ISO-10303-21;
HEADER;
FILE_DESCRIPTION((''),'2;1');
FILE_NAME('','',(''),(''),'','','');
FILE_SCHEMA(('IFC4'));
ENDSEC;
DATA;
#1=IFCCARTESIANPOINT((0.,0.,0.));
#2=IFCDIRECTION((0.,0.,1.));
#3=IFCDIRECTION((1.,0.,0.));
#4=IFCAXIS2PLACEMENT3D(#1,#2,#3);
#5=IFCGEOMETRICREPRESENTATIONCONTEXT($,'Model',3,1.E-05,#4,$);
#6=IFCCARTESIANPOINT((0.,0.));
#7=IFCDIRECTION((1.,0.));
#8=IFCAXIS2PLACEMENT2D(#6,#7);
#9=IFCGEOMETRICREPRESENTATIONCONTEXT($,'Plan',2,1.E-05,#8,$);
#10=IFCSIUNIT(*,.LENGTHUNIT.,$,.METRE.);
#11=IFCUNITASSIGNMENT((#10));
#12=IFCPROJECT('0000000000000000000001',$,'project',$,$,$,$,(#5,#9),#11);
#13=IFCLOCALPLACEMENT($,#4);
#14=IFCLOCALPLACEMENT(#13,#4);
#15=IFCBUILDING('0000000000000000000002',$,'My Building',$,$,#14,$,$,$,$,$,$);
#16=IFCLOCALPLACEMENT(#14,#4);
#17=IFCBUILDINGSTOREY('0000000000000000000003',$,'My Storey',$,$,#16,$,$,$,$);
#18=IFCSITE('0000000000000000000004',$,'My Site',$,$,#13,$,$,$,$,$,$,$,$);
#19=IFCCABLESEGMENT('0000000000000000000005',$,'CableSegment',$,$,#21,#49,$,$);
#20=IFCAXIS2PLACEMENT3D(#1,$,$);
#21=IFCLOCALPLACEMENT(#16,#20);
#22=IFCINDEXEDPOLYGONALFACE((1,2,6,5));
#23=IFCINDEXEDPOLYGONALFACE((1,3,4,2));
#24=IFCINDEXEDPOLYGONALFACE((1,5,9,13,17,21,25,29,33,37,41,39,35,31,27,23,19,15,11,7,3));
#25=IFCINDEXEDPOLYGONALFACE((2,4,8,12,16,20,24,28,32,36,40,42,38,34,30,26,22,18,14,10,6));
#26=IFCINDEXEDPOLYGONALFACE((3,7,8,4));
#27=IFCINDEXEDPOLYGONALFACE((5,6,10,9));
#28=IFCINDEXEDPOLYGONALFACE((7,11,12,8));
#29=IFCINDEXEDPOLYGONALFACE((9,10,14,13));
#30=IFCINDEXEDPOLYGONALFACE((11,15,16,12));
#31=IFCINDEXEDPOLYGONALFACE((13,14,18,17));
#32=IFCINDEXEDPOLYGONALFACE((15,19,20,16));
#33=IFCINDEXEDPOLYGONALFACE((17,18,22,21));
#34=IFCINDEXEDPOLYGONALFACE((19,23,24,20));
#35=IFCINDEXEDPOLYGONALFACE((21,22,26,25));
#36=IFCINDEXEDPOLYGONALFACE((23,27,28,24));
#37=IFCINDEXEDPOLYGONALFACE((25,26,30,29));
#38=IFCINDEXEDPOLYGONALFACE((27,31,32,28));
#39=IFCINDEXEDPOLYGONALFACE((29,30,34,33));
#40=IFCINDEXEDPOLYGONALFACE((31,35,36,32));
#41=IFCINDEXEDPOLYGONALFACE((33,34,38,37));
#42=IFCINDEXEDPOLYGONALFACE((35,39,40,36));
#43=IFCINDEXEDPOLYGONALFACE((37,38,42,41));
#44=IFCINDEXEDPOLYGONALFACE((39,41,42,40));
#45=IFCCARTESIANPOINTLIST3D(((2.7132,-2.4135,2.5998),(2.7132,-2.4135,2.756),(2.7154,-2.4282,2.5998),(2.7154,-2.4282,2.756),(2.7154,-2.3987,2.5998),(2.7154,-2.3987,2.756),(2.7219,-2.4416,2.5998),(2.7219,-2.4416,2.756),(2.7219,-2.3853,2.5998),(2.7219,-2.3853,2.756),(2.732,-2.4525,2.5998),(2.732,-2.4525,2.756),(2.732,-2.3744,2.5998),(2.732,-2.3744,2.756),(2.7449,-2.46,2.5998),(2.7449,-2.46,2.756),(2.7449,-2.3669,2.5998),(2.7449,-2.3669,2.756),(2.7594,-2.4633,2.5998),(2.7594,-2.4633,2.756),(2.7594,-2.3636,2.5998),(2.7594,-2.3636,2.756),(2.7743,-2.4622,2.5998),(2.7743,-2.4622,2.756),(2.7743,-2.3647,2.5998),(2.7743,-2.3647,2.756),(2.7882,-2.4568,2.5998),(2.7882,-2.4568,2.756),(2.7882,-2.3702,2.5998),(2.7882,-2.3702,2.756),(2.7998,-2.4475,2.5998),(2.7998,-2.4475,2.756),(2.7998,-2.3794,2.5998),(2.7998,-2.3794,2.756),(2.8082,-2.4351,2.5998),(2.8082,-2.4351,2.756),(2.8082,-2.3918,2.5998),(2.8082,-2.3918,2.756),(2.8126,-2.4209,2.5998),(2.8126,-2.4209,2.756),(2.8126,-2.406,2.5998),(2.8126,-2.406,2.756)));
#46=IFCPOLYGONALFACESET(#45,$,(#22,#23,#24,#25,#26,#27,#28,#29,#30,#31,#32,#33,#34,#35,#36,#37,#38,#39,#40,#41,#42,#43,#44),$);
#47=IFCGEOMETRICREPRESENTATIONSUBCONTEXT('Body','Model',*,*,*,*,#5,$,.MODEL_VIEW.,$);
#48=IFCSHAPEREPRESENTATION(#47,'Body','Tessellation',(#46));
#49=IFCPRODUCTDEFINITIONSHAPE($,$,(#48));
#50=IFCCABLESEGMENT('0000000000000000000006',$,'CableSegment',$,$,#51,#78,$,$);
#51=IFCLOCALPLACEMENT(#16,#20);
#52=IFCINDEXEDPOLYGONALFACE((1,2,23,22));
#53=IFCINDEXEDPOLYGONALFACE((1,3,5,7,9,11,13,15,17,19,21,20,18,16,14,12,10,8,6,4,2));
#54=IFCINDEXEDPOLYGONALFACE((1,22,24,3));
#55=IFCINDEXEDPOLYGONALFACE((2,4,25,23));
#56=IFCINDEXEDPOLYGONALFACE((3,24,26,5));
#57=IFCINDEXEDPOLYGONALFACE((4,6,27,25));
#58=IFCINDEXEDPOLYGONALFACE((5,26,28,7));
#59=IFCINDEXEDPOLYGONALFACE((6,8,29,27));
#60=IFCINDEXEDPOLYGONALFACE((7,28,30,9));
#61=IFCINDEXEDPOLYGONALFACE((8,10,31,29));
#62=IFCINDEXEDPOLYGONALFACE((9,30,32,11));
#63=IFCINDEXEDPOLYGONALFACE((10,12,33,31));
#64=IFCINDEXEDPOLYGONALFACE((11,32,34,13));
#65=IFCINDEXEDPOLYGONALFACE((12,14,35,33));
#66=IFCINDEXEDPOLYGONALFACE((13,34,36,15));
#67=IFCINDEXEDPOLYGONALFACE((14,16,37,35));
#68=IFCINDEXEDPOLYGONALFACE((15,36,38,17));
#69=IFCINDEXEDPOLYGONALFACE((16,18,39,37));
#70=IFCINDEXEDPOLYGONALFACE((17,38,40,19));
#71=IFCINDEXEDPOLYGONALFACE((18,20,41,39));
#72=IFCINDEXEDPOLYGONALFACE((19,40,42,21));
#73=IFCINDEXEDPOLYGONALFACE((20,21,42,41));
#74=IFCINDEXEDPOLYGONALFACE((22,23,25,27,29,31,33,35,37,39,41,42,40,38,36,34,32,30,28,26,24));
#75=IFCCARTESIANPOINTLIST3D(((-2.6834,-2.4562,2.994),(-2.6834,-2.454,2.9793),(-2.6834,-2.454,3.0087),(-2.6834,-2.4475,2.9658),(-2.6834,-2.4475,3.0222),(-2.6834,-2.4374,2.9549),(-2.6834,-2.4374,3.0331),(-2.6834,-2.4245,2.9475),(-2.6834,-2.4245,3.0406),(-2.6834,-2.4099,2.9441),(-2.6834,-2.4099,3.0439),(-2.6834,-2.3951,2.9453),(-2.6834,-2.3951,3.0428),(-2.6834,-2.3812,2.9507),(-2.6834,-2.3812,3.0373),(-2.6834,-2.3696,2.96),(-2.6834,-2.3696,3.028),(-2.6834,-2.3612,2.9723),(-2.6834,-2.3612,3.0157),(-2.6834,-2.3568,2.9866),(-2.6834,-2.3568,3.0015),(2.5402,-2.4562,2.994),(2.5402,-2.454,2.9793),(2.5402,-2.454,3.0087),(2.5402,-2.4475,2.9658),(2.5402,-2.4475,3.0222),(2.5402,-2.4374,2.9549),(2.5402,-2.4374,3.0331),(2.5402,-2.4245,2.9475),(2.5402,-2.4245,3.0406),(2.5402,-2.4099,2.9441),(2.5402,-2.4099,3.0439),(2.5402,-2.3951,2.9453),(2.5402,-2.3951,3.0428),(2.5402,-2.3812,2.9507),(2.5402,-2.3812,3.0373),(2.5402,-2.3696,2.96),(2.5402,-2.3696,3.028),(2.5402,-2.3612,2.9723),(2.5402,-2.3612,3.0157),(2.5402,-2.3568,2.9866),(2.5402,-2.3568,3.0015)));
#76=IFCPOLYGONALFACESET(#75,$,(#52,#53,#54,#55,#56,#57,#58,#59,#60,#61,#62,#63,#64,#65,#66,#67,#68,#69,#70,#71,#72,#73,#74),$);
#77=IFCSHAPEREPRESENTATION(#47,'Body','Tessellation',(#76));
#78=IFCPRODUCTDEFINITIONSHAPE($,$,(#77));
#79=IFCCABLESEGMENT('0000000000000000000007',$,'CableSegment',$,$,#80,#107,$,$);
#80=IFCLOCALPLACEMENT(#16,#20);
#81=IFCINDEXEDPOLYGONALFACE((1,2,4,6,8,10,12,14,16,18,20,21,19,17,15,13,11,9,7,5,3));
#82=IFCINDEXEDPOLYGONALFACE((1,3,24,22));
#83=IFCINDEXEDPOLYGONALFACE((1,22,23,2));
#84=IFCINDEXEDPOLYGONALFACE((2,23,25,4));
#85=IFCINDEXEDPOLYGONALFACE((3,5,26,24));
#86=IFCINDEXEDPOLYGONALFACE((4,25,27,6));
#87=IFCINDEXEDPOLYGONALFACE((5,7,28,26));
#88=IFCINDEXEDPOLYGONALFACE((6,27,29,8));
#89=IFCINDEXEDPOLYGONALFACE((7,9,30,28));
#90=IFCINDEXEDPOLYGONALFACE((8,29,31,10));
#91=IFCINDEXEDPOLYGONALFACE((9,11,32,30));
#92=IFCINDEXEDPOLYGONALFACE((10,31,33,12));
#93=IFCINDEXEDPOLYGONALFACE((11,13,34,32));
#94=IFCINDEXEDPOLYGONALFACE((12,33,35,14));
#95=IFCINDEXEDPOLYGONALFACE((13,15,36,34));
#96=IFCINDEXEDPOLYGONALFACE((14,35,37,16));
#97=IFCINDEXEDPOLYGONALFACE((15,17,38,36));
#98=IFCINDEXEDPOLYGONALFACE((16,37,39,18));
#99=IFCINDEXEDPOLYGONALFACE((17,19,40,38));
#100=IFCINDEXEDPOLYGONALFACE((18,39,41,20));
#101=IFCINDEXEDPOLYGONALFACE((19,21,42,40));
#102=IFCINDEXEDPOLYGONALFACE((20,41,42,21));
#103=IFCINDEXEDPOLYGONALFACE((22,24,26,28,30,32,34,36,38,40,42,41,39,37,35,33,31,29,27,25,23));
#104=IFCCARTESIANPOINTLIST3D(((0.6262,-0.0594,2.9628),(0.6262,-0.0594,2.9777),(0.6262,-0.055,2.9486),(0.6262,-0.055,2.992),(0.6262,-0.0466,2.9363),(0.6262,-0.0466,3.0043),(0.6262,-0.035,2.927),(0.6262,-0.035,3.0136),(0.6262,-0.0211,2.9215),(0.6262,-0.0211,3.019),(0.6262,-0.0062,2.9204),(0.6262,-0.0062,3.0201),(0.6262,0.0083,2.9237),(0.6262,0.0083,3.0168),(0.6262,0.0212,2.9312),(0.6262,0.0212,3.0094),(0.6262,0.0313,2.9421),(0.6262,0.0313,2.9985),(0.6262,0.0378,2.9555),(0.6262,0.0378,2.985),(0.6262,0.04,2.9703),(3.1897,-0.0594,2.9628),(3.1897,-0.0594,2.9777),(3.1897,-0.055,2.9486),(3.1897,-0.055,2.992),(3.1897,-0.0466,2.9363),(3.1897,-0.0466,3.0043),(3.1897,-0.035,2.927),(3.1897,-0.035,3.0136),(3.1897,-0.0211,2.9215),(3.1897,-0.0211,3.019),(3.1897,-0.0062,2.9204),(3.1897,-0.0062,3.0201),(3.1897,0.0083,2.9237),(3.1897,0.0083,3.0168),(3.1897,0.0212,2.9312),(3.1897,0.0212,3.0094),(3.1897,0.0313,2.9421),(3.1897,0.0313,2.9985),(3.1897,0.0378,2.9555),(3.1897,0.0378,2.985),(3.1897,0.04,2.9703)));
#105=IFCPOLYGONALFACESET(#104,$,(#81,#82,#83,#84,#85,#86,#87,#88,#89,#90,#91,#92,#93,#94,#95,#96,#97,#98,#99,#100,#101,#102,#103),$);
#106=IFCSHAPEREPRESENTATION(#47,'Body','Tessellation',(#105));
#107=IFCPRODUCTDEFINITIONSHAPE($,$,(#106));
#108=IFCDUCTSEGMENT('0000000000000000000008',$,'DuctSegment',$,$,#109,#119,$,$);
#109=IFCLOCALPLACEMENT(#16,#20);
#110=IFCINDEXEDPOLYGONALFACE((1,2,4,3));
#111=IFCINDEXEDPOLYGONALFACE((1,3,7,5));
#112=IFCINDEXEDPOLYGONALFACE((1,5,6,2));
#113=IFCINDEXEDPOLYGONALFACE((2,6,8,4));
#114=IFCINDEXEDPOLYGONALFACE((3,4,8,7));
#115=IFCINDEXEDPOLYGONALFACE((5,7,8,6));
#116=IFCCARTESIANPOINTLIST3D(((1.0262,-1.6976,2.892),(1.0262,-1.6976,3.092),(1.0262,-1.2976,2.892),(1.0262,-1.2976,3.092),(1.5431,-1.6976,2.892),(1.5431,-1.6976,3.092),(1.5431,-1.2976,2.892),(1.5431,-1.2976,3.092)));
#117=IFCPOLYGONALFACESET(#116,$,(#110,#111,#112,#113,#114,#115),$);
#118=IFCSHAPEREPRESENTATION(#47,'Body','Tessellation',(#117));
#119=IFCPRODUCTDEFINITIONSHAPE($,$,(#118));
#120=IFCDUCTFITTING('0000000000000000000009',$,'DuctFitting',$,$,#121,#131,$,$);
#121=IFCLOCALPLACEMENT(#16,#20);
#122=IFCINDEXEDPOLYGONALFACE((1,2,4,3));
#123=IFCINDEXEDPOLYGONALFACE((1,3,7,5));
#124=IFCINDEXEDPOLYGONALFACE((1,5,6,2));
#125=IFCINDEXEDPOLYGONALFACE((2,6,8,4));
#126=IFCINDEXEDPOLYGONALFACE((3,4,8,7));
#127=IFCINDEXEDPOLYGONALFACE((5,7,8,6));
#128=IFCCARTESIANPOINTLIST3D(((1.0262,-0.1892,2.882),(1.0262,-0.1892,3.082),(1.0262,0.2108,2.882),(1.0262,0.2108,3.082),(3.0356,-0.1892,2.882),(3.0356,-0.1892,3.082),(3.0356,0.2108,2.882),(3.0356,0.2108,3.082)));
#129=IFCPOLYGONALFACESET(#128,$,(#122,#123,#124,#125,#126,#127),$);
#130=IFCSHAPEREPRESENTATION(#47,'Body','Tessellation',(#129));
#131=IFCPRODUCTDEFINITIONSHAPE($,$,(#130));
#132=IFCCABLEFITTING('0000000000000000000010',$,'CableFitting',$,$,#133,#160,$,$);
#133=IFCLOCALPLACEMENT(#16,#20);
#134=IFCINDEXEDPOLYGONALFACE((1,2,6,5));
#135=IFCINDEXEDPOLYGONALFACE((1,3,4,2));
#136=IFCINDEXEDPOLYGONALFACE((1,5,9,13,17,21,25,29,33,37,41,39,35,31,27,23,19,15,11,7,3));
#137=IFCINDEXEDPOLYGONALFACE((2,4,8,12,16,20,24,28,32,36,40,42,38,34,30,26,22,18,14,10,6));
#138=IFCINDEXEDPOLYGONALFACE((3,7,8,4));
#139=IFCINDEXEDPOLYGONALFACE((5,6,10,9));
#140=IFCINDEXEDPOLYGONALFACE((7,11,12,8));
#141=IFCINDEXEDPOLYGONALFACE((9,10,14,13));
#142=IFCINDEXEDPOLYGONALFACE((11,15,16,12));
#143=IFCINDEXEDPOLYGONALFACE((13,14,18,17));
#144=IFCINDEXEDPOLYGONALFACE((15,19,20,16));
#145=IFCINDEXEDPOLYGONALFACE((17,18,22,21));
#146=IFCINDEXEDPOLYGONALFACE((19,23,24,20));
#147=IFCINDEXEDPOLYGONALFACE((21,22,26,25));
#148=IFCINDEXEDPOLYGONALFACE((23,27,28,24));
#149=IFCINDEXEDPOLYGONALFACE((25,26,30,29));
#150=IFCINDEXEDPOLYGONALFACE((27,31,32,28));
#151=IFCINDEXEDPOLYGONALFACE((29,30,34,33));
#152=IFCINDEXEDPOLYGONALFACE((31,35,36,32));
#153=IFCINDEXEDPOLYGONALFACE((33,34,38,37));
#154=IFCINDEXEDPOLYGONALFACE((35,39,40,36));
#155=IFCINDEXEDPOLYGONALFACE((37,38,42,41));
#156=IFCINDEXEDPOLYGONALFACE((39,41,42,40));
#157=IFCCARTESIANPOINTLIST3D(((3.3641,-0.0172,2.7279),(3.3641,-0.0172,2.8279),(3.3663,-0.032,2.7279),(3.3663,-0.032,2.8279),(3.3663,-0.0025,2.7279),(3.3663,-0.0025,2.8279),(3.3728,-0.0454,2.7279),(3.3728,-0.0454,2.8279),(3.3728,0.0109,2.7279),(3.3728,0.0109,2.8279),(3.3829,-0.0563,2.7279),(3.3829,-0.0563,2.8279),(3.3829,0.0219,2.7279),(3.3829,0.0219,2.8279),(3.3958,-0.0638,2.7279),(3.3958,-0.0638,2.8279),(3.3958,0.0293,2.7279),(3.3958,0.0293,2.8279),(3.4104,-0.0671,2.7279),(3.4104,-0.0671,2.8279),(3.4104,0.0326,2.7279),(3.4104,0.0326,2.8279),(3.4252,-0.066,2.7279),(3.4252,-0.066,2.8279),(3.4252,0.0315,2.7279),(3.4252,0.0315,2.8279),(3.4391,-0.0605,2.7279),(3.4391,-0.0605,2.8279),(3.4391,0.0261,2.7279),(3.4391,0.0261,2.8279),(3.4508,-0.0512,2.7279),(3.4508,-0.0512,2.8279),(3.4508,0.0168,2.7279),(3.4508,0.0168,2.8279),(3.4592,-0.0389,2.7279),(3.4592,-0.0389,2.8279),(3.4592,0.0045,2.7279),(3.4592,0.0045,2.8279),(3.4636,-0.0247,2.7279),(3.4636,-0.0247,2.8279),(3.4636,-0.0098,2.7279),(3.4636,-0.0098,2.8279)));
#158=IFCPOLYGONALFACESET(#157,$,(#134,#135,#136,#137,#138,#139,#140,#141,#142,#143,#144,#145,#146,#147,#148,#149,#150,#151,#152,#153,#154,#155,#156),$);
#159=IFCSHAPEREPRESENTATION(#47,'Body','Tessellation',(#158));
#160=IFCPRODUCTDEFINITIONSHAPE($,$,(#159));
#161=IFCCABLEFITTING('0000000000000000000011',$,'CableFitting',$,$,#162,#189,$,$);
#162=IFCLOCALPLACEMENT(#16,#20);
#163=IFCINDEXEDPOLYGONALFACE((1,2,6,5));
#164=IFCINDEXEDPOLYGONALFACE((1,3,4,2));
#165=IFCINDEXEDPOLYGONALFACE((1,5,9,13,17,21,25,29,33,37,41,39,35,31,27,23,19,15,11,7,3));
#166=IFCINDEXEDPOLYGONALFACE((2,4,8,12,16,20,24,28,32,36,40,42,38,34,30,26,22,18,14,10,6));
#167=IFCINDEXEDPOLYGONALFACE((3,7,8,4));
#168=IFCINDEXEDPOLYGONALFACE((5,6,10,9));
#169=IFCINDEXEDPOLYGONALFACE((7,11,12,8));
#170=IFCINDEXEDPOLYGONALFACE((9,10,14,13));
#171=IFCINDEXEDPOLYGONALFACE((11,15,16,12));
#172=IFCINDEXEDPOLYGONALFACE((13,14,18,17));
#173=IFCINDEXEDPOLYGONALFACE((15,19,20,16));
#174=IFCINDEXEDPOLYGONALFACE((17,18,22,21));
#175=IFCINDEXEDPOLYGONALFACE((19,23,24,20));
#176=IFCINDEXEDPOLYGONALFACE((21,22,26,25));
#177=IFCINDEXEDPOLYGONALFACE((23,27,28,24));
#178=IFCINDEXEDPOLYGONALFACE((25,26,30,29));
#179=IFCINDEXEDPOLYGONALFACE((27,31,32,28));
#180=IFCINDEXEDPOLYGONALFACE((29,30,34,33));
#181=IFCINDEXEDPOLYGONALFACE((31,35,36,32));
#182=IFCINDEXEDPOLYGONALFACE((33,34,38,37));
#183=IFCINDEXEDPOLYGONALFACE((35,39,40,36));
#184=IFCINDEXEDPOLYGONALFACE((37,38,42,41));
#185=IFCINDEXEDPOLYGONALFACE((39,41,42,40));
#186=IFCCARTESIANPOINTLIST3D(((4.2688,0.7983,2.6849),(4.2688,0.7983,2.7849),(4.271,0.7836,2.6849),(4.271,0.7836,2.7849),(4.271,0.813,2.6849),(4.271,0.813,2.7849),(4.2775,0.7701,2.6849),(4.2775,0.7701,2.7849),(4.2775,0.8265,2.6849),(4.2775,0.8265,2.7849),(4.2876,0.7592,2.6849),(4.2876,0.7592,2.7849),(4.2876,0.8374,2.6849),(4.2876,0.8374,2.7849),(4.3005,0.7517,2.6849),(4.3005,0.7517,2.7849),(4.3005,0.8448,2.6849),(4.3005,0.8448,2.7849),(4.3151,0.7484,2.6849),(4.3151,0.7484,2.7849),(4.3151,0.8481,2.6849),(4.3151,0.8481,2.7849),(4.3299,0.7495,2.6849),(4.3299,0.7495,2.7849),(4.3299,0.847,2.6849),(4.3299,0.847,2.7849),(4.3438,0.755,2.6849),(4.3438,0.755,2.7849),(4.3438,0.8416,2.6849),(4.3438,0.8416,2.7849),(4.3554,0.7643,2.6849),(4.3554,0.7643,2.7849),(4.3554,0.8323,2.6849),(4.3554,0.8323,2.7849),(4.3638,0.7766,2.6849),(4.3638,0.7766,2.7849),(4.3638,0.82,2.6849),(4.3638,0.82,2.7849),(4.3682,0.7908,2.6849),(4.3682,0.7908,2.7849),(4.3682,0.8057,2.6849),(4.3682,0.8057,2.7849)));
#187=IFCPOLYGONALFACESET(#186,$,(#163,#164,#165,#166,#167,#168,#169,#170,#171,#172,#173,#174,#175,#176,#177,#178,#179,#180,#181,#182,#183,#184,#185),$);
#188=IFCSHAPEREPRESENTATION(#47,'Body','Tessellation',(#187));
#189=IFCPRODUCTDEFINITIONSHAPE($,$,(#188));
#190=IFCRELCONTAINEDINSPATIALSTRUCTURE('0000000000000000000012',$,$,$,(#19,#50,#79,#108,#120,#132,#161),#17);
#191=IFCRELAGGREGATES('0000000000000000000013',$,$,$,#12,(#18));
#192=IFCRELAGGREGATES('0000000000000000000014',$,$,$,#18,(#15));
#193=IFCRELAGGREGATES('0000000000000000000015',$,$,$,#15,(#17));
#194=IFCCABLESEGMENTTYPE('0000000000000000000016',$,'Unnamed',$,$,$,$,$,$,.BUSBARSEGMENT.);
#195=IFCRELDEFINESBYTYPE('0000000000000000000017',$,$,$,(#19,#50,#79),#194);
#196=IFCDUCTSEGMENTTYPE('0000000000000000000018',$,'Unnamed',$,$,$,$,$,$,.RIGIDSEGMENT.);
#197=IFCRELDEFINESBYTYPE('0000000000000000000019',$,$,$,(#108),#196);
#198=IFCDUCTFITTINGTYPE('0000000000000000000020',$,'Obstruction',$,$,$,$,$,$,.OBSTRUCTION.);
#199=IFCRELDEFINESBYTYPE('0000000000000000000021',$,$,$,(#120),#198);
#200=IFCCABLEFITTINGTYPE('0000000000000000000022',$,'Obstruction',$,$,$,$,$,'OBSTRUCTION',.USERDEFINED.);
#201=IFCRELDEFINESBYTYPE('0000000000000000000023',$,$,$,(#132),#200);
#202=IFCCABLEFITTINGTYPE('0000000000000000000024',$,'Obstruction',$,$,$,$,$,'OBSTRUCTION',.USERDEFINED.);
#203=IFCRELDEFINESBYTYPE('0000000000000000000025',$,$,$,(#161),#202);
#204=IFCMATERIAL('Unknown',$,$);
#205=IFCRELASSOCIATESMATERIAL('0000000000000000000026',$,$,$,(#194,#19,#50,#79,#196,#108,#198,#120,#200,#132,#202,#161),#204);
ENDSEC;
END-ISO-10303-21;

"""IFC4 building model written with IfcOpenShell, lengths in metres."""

from ifc_helpers import new_model, si_unit, frame, origin_with_axes, origin_2d_with_axis, place, context, subcontext, project, spatial, rectangle, circle, extrude, material, material_profile, profile_set, profile_usage, type_object, element, save


model = new_model("IFC4")

# Units and contexts
model_context = context("Model", 3, precision=1e-05, world=origin_with_axes())
plan_context = context("Plan", 2, precision=1e-05, world=origin_2d_with_axis())
body_context_1 = subcontext(model_context, "Body", "Model", "MODEL_VIEW")
ifc_project = project(units=[si_unit("LENGTHUNIT", "METRE")], contexts=[model_context, plan_context])

# Site, building, storey
site_placement = place(None, origin_with_axes())
site = spatial("IfcSite", under=ifc_project, at=site_placement, Name="My Site")
building_placement = place(site_placement, origin_with_axes())
building = spatial("IfcBuilding", under=site, at=building_placement, Name="My Building")
storey_placement = place(building_placement, origin_with_axes())
storey = spatial("IfcBuildingStorey", under=building, at=storey_placement, Name="My Storey")

# Shared definitions
ifc_material = material(Name="Unknown")

# Cable segments
ifc_material_profile_1 = material_profile(ifc_material, circle(Radius=0.05))
ifc_profile_set_1 = profile_set([ifc_material_profile_1])
cable_segment_type = type_object("IfcCableSegmentType", Name="Unnamed", PredefinedType="BUSBARSEGMENT", material=ifc_profile_set_1)
ifc_profile_usage_1 = profile_usage(ifc_profile_set_1, cardinal=5)
cable_segment_1_placement = place(storey_placement, frame((2.7632, -2.4135, 2.756), z_axis=(0.0, 0.0, -1.0), x_axis=(-1.0, 0.0, 0.0)))
element("IfcCableSegment", 1, at=cable_segment_1_placement, inside=storey, type_object=cable_segment_type, material=ifc_profile_usage_1, Name="CableSegment", context=body_context_1, shape_type="SweptSolid", body=[
    extrude(circle(Radius=0.05), origin_with_axes(), (0.0, 0.0, 1.0), 0.1561),
])
ifc_profile_usage_2 = profile_usage(ifc_profile_set_1, cardinal=5)
cable_segment_2_placement = place(storey_placement, frame((2.5402, -2.4062, 2.994), z_axis=(-1.0, 0.0, 0.0), x_axis=(0.0, -1.0, 0.0)))
element("IfcCableSegment", 2, at=cable_segment_2_placement, inside=storey, type_object=cable_segment_type, material=ifc_profile_usage_2, Name="CableSegment", context=body_context_1, shape_type="SweptSolid", body=[
    extrude(circle(Radius=0.05), origin_with_axes(), (0.0, 0.0, 1.0), 5.2236),
])
ifc_profile_usage_3 = profile_usage(ifc_profile_set_1, cardinal=5)
cable_segment_3_placement = place(storey_placement, frame((0.6262, -0.01, 2.9703), z_axis=(1.0, 0.0, 0.0), x_axis=(0.0, 1.0, 0.0)))
element("IfcCableSegment", 3, at=cable_segment_3_placement, inside=storey, type_object=cable_segment_type, material=ifc_profile_usage_3, Name="CableSegment", context=body_context_1, shape_type="SweptSolid", body=[
    extrude(circle(Radius=0.05), origin_with_axes(), (0.0, 0.0, 1.0), 2.5635),
])

# Duct segment
ifc_material_profile_2 = material_profile(ifc_material, rectangle(XDim=0.4, YDim=0.2))
ifc_profile_set_2 = profile_set([ifc_material_profile_2])
ifc_profile_usage_4 = profile_usage(ifc_profile_set_2, cardinal=5)
duct_segment_type_1 = type_object("IfcDuctSegmentType", Name="Unnamed", PredefinedType="RIGIDSEGMENT", material=ifc_profile_set_2)
duct_segment_1_placement = place(storey_placement, frame((1.0262, -1.4976, 2.992), z_axis=(1.0, 0.0, 0.0), x_axis=(0.0, 1.0, 0.0)))
element("IfcDuctSegment", 4, at=duct_segment_1_placement, inside=storey, type_object=duct_segment_type_1, material=ifc_profile_usage_4, Name="DuctSegment", context=body_context_1, shape_type="SweptSolid", body=[
    extrude(rectangle(XDim=0.4, YDim=0.2), origin_with_axes(), (0.0, 0.0, 1.0), 0.517),
])

# Duct fitting
ifc_material_profile_3 = material_profile(ifc_material, rectangle(XDim=0.4, YDim=0.2))
ifc_profile_set_3 = profile_set([ifc_material_profile_3])
ifc_profile_usage_5 = profile_usage(ifc_profile_set_3, cardinal=5)
duct_fitting_type_1 = type_object("IfcDuctFittingType", Name="Obstruction", PredefinedType="OBSTRUCTION", material=ifc_profile_set_3)
duct_fitting_1_placement = place(storey_placement, frame((1.0262, 0.0108, 2.982), z_axis=(1.0, 0.0, 0.0), x_axis=(0.0, 1.0, 0.0)))
element("IfcDuctFitting", 5, at=duct_fitting_1_placement, inside=storey, type_object=duct_fitting_type_1, material=ifc_profile_usage_5, Name="DuctFitting", context=body_context_1, shape_type="SweptSolid", body=[
    extrude(rectangle(XDim=0.4, YDim=0.2), origin_with_axes(), (0.0, 0.0, 1.0), 2.0094),
])

# Cable fittings
ifc_material_profile_4 = material_profile(ifc_material, circle(Radius=0.05))
ifc_profile_set_4 = profile_set([ifc_material_profile_4])
ifc_profile_usage_6 = profile_usage(ifc_profile_set_4, cardinal=5)
cable_fitting_type_1 = type_object("IfcCableFittingType", Name="Obstruction", ElementType="OBSTRUCTION", PredefinedType="USERDEFINED", material=ifc_profile_set_4)
cable_fitting_1_placement = place(storey_placement, frame((3.4141, -0.0172, 2.8279), z_axis=(0.0, 0.0, -1.0), x_axis=(-1.0, 0.0, 0.0)))
element("IfcCableFitting", 6, at=cable_fitting_1_placement, inside=storey, type_object=cable_fitting_type_1, material=ifc_profile_usage_6, Name="CableFitting", context=body_context_1, shape_type="SweptSolid", body=[
    extrude(circle(Radius=0.05), origin_with_axes(), (0.0, 0.0, 1.0), 0.1),
])
ifc_material_profile_5 = material_profile(ifc_material, circle(Radius=0.05))
ifc_profile_set_5 = profile_set([ifc_material_profile_5])
ifc_profile_usage_7 = profile_usage(ifc_profile_set_5, cardinal=5)
cable_fitting_type_2 = type_object("IfcCableFittingType", Name="Obstruction", ElementType="OBSTRUCTION", PredefinedType="USERDEFINED", material=ifc_profile_set_5)
cable_fitting_2_placement = place(storey_placement, frame((4.3188, 0.7983, 2.7849), z_axis=(0.0, 0.0, -1.0), x_axis=(-1.0, 0.0, 0.0)))
element("IfcCableFitting", 7, at=cable_fitting_2_placement, inside=storey, type_object=cable_fitting_type_2, material=ifc_profile_usage_7, Name="CableFitting", context=body_context_1, shape_type="SweptSolid", body=[
    extrude(circle(Radius=0.05), origin_with_axes(), (0.0, 0.0, 1.0), 0.1),
])

save(model, "model.ifc")
